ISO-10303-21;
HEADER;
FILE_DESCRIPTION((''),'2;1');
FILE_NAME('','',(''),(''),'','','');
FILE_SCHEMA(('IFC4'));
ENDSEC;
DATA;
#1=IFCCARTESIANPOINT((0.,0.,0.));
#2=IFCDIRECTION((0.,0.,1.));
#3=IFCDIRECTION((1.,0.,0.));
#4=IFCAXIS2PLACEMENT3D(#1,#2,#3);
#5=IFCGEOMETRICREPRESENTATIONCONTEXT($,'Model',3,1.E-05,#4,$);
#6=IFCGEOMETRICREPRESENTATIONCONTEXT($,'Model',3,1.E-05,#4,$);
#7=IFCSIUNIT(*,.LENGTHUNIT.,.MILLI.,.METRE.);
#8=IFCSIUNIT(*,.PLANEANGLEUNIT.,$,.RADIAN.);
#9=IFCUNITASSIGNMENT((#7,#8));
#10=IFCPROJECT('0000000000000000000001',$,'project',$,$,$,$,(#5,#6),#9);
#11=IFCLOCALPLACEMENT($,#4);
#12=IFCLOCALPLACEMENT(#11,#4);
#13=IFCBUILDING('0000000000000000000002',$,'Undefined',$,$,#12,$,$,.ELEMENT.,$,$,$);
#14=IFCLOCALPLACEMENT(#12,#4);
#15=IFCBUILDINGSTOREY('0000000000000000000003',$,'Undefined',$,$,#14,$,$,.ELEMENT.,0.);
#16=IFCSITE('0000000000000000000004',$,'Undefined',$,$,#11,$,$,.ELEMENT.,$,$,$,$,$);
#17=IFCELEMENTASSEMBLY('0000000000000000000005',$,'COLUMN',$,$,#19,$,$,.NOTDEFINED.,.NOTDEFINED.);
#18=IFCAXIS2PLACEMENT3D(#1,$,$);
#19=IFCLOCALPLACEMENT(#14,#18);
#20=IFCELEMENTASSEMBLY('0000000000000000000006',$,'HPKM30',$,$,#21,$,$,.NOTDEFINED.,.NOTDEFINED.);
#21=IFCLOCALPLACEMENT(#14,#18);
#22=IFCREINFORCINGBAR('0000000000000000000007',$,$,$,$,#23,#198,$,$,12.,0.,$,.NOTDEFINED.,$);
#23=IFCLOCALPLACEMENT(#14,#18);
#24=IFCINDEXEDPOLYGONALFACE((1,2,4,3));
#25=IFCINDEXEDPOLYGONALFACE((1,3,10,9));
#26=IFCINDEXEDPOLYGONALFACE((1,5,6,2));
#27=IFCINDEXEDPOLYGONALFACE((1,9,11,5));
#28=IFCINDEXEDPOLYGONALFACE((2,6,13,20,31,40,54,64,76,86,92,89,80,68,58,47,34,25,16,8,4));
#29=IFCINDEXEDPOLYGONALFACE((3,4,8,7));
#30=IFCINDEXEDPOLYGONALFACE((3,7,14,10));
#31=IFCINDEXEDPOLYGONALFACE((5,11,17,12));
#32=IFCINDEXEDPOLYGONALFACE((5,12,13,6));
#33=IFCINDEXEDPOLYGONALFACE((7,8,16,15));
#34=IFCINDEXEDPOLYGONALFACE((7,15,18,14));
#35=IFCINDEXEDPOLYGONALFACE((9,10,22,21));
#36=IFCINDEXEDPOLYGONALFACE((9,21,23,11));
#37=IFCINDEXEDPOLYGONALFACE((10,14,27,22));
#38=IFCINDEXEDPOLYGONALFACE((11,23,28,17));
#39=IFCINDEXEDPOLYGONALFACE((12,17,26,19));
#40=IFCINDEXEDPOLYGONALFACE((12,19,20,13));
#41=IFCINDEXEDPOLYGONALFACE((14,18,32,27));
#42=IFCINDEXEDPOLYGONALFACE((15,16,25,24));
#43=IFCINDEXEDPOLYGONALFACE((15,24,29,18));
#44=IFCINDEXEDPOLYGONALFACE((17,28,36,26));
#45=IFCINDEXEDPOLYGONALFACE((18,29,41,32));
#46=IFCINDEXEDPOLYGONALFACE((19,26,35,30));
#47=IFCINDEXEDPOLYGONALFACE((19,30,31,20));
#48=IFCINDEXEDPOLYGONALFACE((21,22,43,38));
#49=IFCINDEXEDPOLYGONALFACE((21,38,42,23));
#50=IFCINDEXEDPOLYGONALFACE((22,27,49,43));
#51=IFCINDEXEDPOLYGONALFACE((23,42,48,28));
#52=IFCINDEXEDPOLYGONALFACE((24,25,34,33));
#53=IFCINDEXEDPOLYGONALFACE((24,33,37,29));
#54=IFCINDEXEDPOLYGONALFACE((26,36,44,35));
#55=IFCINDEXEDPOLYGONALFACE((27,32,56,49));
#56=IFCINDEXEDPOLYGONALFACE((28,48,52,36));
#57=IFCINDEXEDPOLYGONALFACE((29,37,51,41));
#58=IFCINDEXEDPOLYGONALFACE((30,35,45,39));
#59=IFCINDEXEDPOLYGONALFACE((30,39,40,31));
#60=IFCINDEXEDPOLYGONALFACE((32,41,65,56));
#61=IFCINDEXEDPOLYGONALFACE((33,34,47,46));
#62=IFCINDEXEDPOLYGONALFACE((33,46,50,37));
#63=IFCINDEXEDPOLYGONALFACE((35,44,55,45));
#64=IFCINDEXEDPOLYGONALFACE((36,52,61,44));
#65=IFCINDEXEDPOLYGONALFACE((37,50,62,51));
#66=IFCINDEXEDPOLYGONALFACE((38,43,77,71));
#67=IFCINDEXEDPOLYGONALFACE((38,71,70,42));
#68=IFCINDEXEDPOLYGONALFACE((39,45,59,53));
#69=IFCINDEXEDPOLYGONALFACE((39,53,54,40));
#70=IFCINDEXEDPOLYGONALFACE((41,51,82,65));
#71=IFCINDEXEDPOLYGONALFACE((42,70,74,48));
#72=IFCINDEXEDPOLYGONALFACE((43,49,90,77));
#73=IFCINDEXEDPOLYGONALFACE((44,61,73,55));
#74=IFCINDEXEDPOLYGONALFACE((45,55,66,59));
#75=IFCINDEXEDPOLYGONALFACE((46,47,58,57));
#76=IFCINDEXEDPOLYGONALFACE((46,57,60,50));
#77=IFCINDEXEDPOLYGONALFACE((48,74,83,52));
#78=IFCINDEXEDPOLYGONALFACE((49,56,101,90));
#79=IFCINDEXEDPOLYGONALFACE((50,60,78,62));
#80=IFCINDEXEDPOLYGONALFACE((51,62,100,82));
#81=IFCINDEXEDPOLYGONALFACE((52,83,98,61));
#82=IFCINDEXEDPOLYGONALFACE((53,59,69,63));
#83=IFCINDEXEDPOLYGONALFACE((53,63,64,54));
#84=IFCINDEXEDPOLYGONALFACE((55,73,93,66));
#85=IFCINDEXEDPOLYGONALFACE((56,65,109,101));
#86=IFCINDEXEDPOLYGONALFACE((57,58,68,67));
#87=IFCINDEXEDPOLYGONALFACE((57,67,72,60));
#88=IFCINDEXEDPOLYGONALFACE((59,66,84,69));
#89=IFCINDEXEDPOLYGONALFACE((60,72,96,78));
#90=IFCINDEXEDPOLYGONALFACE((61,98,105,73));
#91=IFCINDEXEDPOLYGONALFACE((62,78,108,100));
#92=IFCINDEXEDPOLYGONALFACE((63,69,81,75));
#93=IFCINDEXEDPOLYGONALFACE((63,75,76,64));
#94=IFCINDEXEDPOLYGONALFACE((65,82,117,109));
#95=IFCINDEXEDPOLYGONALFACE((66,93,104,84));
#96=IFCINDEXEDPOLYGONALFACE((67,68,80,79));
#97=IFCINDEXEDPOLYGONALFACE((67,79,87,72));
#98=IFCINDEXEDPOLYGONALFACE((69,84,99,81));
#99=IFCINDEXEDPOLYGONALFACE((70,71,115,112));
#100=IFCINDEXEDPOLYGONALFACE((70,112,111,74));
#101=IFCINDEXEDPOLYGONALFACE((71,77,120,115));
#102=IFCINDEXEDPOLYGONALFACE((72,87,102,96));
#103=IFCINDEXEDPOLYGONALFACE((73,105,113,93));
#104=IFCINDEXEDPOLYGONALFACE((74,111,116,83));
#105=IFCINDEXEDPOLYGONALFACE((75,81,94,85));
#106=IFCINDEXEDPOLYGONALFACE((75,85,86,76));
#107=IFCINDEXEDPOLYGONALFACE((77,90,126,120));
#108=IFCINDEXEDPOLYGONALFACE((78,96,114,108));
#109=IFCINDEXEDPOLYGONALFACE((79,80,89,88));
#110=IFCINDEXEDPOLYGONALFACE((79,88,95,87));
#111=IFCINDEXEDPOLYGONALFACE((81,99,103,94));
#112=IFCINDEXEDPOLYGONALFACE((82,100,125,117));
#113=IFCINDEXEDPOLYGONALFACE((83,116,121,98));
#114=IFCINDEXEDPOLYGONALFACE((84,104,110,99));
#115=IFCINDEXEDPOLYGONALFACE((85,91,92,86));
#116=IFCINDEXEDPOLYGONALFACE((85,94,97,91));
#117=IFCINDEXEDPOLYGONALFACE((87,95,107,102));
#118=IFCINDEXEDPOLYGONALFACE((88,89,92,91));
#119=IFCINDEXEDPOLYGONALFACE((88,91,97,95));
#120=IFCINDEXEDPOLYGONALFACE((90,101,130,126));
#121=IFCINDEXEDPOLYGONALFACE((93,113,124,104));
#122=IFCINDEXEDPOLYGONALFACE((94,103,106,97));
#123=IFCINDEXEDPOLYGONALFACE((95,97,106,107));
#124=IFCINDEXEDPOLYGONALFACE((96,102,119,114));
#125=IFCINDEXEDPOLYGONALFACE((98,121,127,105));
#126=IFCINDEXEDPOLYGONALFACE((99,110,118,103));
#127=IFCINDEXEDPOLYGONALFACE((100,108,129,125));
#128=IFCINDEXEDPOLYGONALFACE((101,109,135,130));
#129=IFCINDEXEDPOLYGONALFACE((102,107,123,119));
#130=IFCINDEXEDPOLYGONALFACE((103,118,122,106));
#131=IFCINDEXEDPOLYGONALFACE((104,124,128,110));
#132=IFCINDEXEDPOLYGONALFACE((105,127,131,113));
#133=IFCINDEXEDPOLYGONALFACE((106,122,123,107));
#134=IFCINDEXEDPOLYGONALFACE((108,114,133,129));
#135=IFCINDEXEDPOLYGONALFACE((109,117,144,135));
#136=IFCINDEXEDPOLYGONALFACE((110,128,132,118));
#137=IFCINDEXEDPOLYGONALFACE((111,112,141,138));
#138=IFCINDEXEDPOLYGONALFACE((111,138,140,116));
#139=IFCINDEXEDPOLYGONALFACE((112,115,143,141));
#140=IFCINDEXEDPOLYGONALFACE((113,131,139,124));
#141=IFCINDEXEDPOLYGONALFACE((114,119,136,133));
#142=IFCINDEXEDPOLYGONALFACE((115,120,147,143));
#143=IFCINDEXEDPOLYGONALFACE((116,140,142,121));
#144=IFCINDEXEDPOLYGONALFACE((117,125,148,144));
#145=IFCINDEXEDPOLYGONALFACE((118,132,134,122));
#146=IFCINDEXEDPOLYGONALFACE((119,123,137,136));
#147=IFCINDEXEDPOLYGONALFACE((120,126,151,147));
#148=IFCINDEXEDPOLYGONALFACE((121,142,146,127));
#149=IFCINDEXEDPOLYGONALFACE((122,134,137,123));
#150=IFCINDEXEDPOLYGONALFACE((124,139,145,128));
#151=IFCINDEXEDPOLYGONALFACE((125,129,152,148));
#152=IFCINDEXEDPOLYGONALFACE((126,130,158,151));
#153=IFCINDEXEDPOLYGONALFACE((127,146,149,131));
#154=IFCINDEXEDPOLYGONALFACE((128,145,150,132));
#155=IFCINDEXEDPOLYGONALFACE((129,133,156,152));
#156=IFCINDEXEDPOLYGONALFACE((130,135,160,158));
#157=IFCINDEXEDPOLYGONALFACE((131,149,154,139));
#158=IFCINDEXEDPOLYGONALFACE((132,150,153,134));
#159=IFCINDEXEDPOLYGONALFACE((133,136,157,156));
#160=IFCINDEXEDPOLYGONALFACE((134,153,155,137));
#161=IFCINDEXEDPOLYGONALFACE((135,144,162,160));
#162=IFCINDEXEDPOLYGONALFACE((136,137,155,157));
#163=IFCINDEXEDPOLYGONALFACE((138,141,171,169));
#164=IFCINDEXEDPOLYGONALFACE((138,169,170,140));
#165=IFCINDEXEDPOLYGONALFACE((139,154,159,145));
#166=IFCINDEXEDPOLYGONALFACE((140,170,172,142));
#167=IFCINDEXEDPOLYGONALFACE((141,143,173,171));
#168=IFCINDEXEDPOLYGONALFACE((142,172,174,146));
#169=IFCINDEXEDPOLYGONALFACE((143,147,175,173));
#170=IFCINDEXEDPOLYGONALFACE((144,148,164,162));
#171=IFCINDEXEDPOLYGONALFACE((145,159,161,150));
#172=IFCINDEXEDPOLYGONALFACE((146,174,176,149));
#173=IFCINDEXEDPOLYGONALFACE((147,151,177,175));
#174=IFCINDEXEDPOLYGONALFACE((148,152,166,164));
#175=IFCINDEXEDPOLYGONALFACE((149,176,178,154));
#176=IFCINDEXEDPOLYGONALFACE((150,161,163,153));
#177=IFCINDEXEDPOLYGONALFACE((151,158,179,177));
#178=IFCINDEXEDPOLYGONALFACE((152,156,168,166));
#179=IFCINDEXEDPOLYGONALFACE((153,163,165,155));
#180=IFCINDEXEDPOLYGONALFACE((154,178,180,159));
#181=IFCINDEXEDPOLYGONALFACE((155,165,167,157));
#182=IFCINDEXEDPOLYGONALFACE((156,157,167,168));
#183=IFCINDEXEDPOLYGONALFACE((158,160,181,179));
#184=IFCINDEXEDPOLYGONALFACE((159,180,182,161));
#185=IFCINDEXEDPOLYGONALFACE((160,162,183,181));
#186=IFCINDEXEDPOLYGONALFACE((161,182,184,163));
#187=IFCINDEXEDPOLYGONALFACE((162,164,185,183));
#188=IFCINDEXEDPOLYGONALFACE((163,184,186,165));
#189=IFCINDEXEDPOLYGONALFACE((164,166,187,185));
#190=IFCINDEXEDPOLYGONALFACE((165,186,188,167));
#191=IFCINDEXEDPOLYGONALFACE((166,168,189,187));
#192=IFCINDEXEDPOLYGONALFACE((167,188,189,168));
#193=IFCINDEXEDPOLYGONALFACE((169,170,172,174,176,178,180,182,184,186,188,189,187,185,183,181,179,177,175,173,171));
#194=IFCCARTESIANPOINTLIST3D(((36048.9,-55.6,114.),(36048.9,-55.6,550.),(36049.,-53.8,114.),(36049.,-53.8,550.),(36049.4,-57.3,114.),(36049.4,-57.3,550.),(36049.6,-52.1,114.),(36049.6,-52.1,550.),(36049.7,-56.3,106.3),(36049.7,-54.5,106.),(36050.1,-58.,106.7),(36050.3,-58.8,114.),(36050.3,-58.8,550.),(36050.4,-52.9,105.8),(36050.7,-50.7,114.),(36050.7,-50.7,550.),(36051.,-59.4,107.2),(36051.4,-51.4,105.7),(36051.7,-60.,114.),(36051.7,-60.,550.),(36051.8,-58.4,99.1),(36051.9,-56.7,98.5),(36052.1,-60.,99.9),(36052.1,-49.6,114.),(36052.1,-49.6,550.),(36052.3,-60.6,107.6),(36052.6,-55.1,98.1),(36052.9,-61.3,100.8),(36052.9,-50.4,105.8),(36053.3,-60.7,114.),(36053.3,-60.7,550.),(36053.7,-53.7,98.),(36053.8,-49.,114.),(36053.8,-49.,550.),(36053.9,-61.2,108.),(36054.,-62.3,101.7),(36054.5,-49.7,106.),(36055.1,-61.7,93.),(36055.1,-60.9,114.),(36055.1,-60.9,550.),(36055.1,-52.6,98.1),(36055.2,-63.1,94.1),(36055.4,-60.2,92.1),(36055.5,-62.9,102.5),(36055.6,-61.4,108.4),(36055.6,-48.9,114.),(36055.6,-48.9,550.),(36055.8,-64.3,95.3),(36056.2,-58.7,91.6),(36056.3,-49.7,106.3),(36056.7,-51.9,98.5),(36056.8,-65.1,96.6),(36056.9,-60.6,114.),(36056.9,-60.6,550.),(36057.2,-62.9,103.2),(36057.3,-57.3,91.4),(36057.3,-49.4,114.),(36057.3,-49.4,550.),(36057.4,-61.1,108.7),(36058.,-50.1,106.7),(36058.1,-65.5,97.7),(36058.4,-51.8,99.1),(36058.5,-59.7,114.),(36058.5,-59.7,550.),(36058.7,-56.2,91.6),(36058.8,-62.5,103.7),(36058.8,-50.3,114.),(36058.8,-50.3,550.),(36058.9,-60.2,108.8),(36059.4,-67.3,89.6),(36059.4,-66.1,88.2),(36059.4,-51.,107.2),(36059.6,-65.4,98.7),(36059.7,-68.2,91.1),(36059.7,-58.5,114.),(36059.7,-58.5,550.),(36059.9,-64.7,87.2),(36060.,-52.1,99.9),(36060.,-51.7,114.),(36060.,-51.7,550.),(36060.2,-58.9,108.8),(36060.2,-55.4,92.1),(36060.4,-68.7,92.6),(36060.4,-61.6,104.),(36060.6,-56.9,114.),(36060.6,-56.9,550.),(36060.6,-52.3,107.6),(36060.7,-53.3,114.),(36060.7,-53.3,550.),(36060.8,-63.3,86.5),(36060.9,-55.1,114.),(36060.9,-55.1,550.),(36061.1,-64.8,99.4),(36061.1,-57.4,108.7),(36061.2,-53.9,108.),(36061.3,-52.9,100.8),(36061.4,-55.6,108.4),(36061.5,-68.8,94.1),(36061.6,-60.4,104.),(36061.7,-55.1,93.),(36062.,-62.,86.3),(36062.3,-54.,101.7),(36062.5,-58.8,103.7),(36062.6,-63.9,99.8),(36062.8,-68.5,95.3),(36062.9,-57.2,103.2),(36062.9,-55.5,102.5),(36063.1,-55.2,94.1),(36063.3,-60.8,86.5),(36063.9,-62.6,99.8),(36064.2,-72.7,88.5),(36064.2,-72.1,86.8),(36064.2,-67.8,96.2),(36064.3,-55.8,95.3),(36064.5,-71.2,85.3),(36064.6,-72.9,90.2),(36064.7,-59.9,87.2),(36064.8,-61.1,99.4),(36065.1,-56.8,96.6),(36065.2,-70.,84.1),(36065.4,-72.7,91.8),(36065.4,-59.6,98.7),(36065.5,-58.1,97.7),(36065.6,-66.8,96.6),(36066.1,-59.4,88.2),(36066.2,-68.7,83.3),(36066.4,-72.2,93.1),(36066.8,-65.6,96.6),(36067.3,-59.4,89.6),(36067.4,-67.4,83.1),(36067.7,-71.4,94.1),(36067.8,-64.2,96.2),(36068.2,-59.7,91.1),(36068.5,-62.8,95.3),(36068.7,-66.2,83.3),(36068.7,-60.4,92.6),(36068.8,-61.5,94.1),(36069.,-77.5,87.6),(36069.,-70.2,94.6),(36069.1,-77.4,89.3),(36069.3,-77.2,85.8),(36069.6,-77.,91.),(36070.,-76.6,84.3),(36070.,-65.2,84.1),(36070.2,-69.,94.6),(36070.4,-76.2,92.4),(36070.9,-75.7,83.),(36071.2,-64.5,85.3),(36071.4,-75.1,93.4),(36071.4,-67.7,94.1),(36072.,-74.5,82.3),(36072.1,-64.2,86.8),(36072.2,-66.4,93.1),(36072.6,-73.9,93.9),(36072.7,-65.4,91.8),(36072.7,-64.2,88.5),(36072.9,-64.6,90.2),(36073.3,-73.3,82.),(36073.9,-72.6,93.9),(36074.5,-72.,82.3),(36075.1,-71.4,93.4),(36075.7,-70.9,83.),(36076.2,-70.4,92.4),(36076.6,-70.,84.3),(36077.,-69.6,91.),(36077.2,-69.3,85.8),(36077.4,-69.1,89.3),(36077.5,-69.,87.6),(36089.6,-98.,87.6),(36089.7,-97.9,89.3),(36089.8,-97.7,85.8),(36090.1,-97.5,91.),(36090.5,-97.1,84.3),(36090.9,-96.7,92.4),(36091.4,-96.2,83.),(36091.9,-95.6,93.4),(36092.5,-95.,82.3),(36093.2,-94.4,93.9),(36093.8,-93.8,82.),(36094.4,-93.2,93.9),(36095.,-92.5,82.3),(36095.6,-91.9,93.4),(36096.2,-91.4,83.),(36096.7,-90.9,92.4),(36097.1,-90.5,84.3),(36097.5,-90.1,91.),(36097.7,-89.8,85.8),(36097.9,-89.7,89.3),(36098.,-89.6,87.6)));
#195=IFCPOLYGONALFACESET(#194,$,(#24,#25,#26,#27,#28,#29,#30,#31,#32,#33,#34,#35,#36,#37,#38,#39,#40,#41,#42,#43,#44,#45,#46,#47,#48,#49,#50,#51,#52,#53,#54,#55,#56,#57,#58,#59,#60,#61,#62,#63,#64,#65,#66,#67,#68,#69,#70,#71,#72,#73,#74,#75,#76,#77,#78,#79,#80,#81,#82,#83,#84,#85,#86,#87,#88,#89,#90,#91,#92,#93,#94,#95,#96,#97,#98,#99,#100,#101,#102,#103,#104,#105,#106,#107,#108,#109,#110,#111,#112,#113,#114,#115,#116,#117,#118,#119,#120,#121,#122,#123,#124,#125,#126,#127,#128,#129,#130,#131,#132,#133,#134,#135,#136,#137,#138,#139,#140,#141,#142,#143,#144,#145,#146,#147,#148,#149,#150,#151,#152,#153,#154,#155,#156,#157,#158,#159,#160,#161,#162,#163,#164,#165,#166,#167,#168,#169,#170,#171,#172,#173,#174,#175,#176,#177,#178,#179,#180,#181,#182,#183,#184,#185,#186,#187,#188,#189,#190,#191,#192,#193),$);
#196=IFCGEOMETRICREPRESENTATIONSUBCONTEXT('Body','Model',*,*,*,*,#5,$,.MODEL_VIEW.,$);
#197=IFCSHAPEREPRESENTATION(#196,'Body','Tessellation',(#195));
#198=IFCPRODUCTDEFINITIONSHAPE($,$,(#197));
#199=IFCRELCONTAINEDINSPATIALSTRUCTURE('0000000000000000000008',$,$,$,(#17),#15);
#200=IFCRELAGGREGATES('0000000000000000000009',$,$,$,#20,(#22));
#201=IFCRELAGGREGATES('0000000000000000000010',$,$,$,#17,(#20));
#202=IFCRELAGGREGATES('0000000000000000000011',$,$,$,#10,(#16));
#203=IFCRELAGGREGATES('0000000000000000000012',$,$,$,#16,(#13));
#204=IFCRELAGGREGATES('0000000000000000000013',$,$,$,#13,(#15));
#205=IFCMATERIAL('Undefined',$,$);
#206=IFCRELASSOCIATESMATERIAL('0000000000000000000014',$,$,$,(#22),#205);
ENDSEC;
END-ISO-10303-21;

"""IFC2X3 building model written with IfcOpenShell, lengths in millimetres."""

from ifc_helpers import new_model, entity, si_unit, frame, origin_with_axes, place, context, subcontext, project, spatial, source, transform, mapped, material, element, aggregate, save


model = new_model("IFC2X3")

# Units and contexts
model_context_1 = context("Model", 3, precision=1e-05, world=origin_with_axes())
model_context_2 = context("Model", 3, precision=1e-05, world=origin_with_axes())
body_context = subcontext(model_context_1, "Body", "Model", "MODEL_VIEW")
ifc_project = project(units=[si_unit("LENGTHUNIT", "METRE", prefix="MILLI"), si_unit("PLANEANGLEUNIT", "RADIAN")], contexts=[model_context_1, model_context_2])

# Site, building, storey
site_placement = place(None, origin_with_axes())
site = spatial("IfcSite", under=ifc_project, at=site_placement, Name="Undefined", CompositionType="ELEMENT")
building_placement = place(site_placement, origin_with_axes())
building = spatial("IfcBuilding", under=site, at=building_placement, Name="Undefined", CompositionType="ELEMENT")
storey_placement = place(building_placement, origin_with_axes())
storey = spatial("IfcBuildingStorey", under=building, at=storey_placement, Name="Undefined", CompositionType="ELEMENT", Elevation=0.0)

# Element assemblies
assembly_1_placement = place(storey_placement, origin_with_axes())
assembly_1 = element("IfcElementAssembly", 1, at=assembly_1_placement, inside=storey, Name="COLUMN", AssemblyPlace="NOTDEFINED", PredefinedType="NOTDEFINED")
assembly_2_placement = place(assembly_1_placement, origin_with_axes())
assembly_2 = element("IfcElementAssembly", 2, at=assembly_2_placement, Name="HPKM30", AssemblyPlace="NOTDEFINED", PredefinedType="NOTDEFINED")

# Shared definitions
ifc_material_1 = material(Name="Undefined")

# Reinforcing bar
shared_shape_1 = source(origin_with_axes(), body_context, "Body", "AdvancedSweptSolid", [
    entity("IfcSweptDiskSolid", entity("IfcCompositeCurve", [entity("IfcCompositeCurveSegment", "CONTINUOUS", True, entity("IfcTrimmedCurve", entity("IfcLine", entity("IfcCartesianPoint", [0.0, 0.0, 0.0]), entity("IfcVector", entity("IfcDirection", [0.0, 0.0, -1.0]), 1.0)), [entity("IfcParameterValue", 0.0)], [entity("IfcParameterValue", 29.0)], True, "PARAMETER")), entity("IfcCompositeCurveSegment", "CONTINUOUS", True, entity("IfcTrimmedCurve", entity("IfcCircle", entity("IfcAxis2Placement3D", entity("IfcCartesianPoint", [26.0, 0.0, -29.0]), entity("IfcDirection", [0.0, -1.0, 0.0]), entity("IfcDirection", [-1.0, 0.0, 0.0])), 26.0), [entity("IfcParameterValue", 0.0)], [entity("IfcParameterValue", 1.570796)], True, "PARAMETER")), entity("IfcCompositeCurveSegment", "DISCONTINUOUS", True, entity("IfcTrimmedCurve", entity("IfcLine", entity("IfcCartesianPoint", [26.0, 0.0, -55.0]), entity("IfcVector", entity("IfcDirection", [1.0, 0.0, 0.0]), 1.0)), [entity("IfcParameterValue", 0.0)], [entity("IfcParameterValue", 436.0)], True, "PARAMETER"))], False), 6.0, None, 0.0, 466.6),
])
reinforcing_bar_1_placement = place(assembly_2_placement, frame((36054.9, -54.9, 88.0), z_axis=(0.707107, -0.707107, 0.0), x_axis=(0.0, 0.0, 1.0)))
reinforcing_bar_1 = element("IfcReinforcingBar", 3, at=reinforcing_bar_1_placement, material=ifc_material_1, BarRole="NOTDEFINED", CrossSectionArea=0.0, NominalDiameter=12.0, context=body_context, shape_type="MappedRepresentation", body=[
    mapped(shared_shape_1, transform((0.0, 0.0, 55.0))),
])
aggregate(assembly_2, [reinforcing_bar_1])
aggregate(assembly_1, [assembly_2])

save(model, "model.ifc")
